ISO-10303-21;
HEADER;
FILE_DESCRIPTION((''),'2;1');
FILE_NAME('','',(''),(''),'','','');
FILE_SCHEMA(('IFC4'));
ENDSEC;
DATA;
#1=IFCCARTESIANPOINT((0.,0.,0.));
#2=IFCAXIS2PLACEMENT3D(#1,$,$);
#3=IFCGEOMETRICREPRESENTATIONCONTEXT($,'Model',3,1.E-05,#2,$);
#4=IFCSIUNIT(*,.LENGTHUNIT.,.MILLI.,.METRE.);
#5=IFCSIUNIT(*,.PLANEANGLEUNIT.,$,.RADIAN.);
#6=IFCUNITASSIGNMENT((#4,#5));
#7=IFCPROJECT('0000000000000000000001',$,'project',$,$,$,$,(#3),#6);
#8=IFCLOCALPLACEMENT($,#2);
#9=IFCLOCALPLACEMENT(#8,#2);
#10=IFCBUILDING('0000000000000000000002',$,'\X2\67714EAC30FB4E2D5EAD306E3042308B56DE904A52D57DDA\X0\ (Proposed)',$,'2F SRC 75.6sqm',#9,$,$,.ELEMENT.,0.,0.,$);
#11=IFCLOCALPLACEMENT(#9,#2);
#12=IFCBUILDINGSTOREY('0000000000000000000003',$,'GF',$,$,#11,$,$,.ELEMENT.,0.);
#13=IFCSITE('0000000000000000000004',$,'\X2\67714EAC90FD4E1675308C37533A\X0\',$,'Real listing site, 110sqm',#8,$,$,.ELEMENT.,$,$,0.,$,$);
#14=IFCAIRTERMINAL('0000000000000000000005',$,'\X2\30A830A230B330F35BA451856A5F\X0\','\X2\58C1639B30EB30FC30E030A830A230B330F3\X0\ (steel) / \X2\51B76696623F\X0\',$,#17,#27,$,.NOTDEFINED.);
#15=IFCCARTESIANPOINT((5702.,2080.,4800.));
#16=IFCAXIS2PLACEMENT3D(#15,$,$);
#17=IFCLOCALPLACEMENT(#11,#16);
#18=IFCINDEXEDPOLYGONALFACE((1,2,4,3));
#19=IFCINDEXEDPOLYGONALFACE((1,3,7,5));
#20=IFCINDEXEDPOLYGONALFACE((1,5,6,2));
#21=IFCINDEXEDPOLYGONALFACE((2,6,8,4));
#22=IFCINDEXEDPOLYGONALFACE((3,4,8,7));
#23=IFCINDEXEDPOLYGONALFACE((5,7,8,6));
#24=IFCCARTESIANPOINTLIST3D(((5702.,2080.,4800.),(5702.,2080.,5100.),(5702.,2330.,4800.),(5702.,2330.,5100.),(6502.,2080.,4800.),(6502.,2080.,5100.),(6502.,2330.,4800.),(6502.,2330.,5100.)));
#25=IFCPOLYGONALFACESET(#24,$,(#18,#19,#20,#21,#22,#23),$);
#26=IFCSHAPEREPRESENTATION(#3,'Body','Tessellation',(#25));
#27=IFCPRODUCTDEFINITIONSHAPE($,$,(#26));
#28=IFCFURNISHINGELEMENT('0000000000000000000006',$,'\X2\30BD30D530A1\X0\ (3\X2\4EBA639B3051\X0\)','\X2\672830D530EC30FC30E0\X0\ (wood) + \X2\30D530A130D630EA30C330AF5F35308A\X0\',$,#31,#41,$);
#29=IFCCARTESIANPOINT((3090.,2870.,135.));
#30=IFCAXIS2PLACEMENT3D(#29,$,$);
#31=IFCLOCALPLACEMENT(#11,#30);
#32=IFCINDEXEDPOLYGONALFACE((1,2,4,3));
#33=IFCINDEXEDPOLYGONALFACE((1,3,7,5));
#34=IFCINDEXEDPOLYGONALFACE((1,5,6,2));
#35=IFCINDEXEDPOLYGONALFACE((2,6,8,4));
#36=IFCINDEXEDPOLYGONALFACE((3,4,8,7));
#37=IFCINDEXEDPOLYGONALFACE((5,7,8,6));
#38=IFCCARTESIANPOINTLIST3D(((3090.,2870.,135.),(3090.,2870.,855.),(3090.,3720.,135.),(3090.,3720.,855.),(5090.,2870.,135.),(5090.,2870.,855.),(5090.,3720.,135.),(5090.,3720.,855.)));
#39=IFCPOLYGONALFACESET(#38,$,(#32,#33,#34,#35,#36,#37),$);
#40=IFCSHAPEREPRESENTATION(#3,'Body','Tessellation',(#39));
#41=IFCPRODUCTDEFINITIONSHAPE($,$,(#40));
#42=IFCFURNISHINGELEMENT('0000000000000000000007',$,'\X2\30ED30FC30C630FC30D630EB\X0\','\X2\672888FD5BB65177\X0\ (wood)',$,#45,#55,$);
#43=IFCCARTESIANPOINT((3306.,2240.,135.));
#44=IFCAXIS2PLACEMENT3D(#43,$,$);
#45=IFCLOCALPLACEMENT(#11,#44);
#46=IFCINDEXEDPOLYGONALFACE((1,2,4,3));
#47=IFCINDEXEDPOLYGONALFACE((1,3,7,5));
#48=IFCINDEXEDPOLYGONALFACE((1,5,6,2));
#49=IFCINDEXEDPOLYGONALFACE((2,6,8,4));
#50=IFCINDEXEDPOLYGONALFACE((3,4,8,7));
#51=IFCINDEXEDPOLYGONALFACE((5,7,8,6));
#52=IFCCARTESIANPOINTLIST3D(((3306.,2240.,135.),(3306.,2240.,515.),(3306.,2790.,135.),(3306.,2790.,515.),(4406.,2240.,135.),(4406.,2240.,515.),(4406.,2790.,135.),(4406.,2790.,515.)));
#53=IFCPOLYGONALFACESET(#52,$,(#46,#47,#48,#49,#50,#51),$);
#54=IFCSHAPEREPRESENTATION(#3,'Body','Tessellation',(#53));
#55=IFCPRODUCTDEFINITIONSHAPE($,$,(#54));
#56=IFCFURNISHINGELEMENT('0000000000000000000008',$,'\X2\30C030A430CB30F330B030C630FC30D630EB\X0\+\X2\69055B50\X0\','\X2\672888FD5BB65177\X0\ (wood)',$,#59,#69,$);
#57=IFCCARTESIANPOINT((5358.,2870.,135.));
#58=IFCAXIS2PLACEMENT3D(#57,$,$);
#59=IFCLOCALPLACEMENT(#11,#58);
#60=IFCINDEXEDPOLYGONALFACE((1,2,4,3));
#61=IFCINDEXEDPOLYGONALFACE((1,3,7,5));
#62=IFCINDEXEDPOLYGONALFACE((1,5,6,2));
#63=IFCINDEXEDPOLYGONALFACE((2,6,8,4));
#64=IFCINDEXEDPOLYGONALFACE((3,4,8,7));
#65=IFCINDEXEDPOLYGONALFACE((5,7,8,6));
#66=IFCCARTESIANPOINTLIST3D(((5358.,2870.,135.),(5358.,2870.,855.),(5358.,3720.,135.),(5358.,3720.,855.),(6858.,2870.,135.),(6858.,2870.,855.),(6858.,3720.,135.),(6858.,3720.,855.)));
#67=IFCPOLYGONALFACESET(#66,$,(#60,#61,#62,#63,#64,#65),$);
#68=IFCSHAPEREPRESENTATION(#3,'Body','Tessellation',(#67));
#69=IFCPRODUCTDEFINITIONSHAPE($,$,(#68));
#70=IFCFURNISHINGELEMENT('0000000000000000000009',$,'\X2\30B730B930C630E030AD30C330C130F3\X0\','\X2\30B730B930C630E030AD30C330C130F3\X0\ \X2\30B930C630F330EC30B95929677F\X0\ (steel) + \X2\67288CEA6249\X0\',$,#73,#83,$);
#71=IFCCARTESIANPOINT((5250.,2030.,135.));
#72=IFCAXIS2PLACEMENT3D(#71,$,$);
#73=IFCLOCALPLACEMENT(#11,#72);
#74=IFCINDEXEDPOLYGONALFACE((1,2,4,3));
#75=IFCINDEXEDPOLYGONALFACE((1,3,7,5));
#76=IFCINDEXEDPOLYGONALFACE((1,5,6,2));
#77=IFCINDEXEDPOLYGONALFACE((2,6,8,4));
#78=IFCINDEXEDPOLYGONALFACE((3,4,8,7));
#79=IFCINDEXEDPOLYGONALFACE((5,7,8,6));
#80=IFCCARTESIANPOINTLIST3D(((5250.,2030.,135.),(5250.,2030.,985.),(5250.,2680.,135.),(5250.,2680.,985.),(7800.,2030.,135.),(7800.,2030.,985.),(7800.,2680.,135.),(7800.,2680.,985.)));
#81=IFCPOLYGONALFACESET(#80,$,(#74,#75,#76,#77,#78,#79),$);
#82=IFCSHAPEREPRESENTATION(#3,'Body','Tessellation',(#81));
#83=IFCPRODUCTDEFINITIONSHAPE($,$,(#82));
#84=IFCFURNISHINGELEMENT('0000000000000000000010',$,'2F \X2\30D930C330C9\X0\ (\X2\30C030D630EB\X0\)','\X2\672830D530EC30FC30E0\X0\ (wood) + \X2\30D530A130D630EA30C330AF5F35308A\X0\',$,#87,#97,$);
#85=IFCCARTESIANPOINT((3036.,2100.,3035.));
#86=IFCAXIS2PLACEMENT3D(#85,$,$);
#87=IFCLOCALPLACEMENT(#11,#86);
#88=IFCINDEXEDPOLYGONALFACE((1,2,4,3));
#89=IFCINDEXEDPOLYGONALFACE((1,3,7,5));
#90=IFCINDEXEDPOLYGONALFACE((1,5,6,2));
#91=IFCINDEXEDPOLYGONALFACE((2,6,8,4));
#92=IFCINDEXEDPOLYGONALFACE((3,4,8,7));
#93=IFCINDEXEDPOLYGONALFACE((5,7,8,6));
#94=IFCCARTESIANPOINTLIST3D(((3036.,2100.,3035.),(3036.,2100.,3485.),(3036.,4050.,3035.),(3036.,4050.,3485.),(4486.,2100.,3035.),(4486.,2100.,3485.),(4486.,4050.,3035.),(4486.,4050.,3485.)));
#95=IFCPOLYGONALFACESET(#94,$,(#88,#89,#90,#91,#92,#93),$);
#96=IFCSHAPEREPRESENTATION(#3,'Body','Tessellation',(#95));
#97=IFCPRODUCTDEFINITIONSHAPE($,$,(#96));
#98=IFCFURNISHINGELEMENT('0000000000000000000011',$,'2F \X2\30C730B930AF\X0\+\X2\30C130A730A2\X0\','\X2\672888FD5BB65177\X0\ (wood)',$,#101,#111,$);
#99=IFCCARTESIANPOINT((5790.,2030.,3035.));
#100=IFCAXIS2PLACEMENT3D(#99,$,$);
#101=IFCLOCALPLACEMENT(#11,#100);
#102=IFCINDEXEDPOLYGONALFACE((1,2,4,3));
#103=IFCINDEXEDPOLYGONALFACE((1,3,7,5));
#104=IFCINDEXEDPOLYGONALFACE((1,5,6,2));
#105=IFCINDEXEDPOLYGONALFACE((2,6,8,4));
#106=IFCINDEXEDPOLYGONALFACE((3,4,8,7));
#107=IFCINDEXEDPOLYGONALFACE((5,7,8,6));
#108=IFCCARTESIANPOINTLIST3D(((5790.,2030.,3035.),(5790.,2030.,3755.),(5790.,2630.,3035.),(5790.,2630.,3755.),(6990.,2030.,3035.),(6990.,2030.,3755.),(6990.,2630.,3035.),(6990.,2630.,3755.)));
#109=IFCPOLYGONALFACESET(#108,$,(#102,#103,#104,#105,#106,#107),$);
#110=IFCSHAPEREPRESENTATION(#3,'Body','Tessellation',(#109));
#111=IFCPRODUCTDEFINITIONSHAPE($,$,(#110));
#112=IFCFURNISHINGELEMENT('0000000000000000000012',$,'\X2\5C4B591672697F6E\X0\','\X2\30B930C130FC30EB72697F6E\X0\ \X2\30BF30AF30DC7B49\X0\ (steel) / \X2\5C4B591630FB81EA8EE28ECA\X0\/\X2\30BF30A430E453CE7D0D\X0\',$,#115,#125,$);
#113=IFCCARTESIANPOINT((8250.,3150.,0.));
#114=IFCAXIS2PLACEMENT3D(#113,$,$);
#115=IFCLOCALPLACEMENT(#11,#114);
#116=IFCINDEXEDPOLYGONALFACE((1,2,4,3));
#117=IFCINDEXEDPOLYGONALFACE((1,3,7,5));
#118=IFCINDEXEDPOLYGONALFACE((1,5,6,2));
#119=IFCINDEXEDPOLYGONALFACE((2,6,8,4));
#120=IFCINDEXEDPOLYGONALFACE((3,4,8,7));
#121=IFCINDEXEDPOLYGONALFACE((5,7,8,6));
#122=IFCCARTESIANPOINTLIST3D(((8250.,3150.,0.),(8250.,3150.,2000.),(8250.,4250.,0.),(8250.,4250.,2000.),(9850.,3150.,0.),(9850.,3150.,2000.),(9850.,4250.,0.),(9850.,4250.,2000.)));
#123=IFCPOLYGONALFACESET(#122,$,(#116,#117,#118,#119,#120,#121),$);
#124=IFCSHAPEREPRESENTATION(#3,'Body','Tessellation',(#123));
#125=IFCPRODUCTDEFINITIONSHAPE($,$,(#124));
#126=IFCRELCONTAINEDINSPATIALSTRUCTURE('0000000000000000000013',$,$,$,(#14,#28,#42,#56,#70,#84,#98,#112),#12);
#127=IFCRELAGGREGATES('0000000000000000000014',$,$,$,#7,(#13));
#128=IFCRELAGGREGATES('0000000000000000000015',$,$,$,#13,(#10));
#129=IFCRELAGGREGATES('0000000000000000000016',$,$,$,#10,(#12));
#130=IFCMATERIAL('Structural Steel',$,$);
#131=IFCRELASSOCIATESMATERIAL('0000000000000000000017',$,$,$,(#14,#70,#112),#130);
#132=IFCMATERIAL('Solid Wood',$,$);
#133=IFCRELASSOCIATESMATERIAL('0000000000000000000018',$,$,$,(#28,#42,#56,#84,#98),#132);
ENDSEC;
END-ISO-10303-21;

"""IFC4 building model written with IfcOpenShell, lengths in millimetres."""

from ifc_helpers import new_model, si_unit, frame, frame_2d, origin, place, context, project, spatial, rectangle, extrude, material, element, save


model = new_model("IFC4")

# Units and contexts
model_context = context("Model", 3, precision=1e-05, world=origin())
ifc_project = project(units=[si_unit("LENGTHUNIT", "METRE", prefix="MILLI"), si_unit("PLANEANGLEUNIT", "RADIAN")], contexts=[model_context])

# Site, building, storey
site_placement = place(None, origin())
site = spatial("IfcSite", under=ifc_project, at=site_placement, Name="東京都世田谷区", ObjectType="Real listing site, 110sqm", CompositionType="ELEMENT", RefElevation=0.0)
building_placement = place(site_placement, origin())
building = spatial("IfcBuilding", under=site, at=building_placement, Name="東京・中庭のある回遊動線 (Proposed)", ObjectType="2F SRC 75.6sqm", CompositionType="ELEMENT", ElevationOfRefHeight=0.0, ElevationOfTerrain=0.0)
storey_placement = place(building_placement, origin())
storey = spatial("IfcBuildingStorey", under=building, at=storey_placement, Name="GF", CompositionType="ELEMENT", Elevation=0.0)

# Shared definitions
ifc_material_1 = material(Name="Solid Wood")

# Shared definitions
ifc_material_2 = material(Name="Structural Steel")

# Air terminal
air_terminal_1_placement = place(storey_placement, frame((5702.0, 2080.0, 4800.0)))
element("IfcAirTerminal", 1, at=air_terminal_1_placement, inside=storey, material=ifc_material_2, Name="エアコン室内機", Description="壁掛ルームエアコン (steel) / 冷暖房", PredefinedType="NOTDEFINED", context=model_context, shape_type="SweptSolid", body=[
    extrude(rectangle(XDim=800.0, YDim=250.0, at=frame_2d((400.0, 125.0))), frame((5702.0, 2080.0, 4800.0)), (0.0, 0.0, 1.0), 300.0),
])

# Furnishing elements
furnishing_1_placement = place(storey_placement, frame((3090.0, 2870.0, 135.0)))
element("IfcFurnishingElement", 2, at=furnishing_1_placement, inside=storey, material=ifc_material_1, Name="ソファ (3人掛け)", Description="木フレーム (wood) + ファブリック張り", context=model_context, shape_type="SweptSolid", body=[
    extrude(rectangle(XDim=2000.0, YDim=850.0, at=frame_2d((1000.0, 425.0))), frame((3090.0, 2870.0, 135.0)), (0.0, 0.0, 1.0), 720.0),
])
furnishing_2_placement = place(storey_placement, frame((3306.0, 2240.0, 135.0)))
element("IfcFurnishingElement", 3, at=furnishing_2_placement, inside=storey, material=ifc_material_1, Name="ローテーブル", Description="木製家具 (wood)", context=model_context, shape_type="SweptSolid", body=[
    extrude(rectangle(XDim=1100.0, YDim=550.0, at=frame_2d((550.0, 275.0))), frame((3306.0, 2240.0, 135.0)), (0.0, 0.0, 1.0), 380.0),
])
furnishing_3_placement = place(storey_placement, frame((5358.0, 2870.0, 135.0)))
element("IfcFurnishingElement", 4, at=furnishing_3_placement, inside=storey, material=ifc_material_1, Name="ダイニングテーブル+椅子", Description="木製家具 (wood)", context=model_context, shape_type="SweptSolid", body=[
    extrude(rectangle(XDim=1500.0, YDim=850.0, at=frame_2d((750.0, 425.0))), frame((5358.0, 2870.0, 135.0)), (0.0, 0.0, 1.0), 720.0),
])
furnishing_4_placement = place(storey_placement, frame((5250.0, 2030.0, 135.0)))
element("IfcFurnishingElement", 5, at=furnishing_4_placement, inside=storey, material=ifc_material_2, Name="システムキッチン", Description="システムキッチン ステンレス天板 (steel) + 木質扉", context=model_context, shape_type="SweptSolid", body=[
    extrude(rectangle(XDim=2550.0, YDim=650.0, at=frame_2d((1275.0, 325.0))), frame((5250.0, 2030.0, 135.0)), (0.0, 0.0, 1.0), 850.0),
])
furnishing_5_placement = place(storey_placement, frame((3036.0, 2100.0, 3035.0)))
element("IfcFurnishingElement", 6, at=furnishing_5_placement, inside=storey, material=ifc_material_1, Name="2F ベッド (ダブル)", Description="木フレーム (wood) + ファブリック張り", context=model_context, shape_type="SweptSolid", body=[
    extrude(rectangle(XDim=1450.0, YDim=1950.0, at=frame_2d((725.0, 975.0))), frame((3036.0, 2100.0, 3035.0)), (0.0, 0.0, 1.0), 450.0),
])
furnishing_6_placement = place(storey_placement, frame((5790.0, 2030.0, 3035.0)))
element("IfcFurnishingElement", 7, at=furnishing_6_placement, inside=storey, material=ifc_material_1, Name="2F デスク+チェア", Description="木製家具 (wood)", context=model_context, shape_type="SweptSolid", body=[
    extrude(rectangle(XDim=1200.0, YDim=600.0, at=frame_2d((600.0, 300.0))), frame((5790.0, 2030.0, 3035.0)), (0.0, 0.0, 1.0), 720.0),
])
furnishing_7_placement = place(storey_placement, frame((8250.0, 3150.0, 0.0)))
element("IfcFurnishingElement", 8, at=furnishing_7_placement, inside=storey, material=ifc_material_2, Name="屋外物置", Description="スチール物置 タクボ等 (steel) / 屋外・自転車/タイヤ収納", context=model_context, shape_type="SweptSolid", body=[
    extrude(rectangle(XDim=1600.0, YDim=1100.0, at=frame_2d((800.0, 550.0))), frame((8250.0, 3150.0, 0.0)), (0.0, 0.0, 1.0), 2000.0),
])

save(model, "model.ifc")
